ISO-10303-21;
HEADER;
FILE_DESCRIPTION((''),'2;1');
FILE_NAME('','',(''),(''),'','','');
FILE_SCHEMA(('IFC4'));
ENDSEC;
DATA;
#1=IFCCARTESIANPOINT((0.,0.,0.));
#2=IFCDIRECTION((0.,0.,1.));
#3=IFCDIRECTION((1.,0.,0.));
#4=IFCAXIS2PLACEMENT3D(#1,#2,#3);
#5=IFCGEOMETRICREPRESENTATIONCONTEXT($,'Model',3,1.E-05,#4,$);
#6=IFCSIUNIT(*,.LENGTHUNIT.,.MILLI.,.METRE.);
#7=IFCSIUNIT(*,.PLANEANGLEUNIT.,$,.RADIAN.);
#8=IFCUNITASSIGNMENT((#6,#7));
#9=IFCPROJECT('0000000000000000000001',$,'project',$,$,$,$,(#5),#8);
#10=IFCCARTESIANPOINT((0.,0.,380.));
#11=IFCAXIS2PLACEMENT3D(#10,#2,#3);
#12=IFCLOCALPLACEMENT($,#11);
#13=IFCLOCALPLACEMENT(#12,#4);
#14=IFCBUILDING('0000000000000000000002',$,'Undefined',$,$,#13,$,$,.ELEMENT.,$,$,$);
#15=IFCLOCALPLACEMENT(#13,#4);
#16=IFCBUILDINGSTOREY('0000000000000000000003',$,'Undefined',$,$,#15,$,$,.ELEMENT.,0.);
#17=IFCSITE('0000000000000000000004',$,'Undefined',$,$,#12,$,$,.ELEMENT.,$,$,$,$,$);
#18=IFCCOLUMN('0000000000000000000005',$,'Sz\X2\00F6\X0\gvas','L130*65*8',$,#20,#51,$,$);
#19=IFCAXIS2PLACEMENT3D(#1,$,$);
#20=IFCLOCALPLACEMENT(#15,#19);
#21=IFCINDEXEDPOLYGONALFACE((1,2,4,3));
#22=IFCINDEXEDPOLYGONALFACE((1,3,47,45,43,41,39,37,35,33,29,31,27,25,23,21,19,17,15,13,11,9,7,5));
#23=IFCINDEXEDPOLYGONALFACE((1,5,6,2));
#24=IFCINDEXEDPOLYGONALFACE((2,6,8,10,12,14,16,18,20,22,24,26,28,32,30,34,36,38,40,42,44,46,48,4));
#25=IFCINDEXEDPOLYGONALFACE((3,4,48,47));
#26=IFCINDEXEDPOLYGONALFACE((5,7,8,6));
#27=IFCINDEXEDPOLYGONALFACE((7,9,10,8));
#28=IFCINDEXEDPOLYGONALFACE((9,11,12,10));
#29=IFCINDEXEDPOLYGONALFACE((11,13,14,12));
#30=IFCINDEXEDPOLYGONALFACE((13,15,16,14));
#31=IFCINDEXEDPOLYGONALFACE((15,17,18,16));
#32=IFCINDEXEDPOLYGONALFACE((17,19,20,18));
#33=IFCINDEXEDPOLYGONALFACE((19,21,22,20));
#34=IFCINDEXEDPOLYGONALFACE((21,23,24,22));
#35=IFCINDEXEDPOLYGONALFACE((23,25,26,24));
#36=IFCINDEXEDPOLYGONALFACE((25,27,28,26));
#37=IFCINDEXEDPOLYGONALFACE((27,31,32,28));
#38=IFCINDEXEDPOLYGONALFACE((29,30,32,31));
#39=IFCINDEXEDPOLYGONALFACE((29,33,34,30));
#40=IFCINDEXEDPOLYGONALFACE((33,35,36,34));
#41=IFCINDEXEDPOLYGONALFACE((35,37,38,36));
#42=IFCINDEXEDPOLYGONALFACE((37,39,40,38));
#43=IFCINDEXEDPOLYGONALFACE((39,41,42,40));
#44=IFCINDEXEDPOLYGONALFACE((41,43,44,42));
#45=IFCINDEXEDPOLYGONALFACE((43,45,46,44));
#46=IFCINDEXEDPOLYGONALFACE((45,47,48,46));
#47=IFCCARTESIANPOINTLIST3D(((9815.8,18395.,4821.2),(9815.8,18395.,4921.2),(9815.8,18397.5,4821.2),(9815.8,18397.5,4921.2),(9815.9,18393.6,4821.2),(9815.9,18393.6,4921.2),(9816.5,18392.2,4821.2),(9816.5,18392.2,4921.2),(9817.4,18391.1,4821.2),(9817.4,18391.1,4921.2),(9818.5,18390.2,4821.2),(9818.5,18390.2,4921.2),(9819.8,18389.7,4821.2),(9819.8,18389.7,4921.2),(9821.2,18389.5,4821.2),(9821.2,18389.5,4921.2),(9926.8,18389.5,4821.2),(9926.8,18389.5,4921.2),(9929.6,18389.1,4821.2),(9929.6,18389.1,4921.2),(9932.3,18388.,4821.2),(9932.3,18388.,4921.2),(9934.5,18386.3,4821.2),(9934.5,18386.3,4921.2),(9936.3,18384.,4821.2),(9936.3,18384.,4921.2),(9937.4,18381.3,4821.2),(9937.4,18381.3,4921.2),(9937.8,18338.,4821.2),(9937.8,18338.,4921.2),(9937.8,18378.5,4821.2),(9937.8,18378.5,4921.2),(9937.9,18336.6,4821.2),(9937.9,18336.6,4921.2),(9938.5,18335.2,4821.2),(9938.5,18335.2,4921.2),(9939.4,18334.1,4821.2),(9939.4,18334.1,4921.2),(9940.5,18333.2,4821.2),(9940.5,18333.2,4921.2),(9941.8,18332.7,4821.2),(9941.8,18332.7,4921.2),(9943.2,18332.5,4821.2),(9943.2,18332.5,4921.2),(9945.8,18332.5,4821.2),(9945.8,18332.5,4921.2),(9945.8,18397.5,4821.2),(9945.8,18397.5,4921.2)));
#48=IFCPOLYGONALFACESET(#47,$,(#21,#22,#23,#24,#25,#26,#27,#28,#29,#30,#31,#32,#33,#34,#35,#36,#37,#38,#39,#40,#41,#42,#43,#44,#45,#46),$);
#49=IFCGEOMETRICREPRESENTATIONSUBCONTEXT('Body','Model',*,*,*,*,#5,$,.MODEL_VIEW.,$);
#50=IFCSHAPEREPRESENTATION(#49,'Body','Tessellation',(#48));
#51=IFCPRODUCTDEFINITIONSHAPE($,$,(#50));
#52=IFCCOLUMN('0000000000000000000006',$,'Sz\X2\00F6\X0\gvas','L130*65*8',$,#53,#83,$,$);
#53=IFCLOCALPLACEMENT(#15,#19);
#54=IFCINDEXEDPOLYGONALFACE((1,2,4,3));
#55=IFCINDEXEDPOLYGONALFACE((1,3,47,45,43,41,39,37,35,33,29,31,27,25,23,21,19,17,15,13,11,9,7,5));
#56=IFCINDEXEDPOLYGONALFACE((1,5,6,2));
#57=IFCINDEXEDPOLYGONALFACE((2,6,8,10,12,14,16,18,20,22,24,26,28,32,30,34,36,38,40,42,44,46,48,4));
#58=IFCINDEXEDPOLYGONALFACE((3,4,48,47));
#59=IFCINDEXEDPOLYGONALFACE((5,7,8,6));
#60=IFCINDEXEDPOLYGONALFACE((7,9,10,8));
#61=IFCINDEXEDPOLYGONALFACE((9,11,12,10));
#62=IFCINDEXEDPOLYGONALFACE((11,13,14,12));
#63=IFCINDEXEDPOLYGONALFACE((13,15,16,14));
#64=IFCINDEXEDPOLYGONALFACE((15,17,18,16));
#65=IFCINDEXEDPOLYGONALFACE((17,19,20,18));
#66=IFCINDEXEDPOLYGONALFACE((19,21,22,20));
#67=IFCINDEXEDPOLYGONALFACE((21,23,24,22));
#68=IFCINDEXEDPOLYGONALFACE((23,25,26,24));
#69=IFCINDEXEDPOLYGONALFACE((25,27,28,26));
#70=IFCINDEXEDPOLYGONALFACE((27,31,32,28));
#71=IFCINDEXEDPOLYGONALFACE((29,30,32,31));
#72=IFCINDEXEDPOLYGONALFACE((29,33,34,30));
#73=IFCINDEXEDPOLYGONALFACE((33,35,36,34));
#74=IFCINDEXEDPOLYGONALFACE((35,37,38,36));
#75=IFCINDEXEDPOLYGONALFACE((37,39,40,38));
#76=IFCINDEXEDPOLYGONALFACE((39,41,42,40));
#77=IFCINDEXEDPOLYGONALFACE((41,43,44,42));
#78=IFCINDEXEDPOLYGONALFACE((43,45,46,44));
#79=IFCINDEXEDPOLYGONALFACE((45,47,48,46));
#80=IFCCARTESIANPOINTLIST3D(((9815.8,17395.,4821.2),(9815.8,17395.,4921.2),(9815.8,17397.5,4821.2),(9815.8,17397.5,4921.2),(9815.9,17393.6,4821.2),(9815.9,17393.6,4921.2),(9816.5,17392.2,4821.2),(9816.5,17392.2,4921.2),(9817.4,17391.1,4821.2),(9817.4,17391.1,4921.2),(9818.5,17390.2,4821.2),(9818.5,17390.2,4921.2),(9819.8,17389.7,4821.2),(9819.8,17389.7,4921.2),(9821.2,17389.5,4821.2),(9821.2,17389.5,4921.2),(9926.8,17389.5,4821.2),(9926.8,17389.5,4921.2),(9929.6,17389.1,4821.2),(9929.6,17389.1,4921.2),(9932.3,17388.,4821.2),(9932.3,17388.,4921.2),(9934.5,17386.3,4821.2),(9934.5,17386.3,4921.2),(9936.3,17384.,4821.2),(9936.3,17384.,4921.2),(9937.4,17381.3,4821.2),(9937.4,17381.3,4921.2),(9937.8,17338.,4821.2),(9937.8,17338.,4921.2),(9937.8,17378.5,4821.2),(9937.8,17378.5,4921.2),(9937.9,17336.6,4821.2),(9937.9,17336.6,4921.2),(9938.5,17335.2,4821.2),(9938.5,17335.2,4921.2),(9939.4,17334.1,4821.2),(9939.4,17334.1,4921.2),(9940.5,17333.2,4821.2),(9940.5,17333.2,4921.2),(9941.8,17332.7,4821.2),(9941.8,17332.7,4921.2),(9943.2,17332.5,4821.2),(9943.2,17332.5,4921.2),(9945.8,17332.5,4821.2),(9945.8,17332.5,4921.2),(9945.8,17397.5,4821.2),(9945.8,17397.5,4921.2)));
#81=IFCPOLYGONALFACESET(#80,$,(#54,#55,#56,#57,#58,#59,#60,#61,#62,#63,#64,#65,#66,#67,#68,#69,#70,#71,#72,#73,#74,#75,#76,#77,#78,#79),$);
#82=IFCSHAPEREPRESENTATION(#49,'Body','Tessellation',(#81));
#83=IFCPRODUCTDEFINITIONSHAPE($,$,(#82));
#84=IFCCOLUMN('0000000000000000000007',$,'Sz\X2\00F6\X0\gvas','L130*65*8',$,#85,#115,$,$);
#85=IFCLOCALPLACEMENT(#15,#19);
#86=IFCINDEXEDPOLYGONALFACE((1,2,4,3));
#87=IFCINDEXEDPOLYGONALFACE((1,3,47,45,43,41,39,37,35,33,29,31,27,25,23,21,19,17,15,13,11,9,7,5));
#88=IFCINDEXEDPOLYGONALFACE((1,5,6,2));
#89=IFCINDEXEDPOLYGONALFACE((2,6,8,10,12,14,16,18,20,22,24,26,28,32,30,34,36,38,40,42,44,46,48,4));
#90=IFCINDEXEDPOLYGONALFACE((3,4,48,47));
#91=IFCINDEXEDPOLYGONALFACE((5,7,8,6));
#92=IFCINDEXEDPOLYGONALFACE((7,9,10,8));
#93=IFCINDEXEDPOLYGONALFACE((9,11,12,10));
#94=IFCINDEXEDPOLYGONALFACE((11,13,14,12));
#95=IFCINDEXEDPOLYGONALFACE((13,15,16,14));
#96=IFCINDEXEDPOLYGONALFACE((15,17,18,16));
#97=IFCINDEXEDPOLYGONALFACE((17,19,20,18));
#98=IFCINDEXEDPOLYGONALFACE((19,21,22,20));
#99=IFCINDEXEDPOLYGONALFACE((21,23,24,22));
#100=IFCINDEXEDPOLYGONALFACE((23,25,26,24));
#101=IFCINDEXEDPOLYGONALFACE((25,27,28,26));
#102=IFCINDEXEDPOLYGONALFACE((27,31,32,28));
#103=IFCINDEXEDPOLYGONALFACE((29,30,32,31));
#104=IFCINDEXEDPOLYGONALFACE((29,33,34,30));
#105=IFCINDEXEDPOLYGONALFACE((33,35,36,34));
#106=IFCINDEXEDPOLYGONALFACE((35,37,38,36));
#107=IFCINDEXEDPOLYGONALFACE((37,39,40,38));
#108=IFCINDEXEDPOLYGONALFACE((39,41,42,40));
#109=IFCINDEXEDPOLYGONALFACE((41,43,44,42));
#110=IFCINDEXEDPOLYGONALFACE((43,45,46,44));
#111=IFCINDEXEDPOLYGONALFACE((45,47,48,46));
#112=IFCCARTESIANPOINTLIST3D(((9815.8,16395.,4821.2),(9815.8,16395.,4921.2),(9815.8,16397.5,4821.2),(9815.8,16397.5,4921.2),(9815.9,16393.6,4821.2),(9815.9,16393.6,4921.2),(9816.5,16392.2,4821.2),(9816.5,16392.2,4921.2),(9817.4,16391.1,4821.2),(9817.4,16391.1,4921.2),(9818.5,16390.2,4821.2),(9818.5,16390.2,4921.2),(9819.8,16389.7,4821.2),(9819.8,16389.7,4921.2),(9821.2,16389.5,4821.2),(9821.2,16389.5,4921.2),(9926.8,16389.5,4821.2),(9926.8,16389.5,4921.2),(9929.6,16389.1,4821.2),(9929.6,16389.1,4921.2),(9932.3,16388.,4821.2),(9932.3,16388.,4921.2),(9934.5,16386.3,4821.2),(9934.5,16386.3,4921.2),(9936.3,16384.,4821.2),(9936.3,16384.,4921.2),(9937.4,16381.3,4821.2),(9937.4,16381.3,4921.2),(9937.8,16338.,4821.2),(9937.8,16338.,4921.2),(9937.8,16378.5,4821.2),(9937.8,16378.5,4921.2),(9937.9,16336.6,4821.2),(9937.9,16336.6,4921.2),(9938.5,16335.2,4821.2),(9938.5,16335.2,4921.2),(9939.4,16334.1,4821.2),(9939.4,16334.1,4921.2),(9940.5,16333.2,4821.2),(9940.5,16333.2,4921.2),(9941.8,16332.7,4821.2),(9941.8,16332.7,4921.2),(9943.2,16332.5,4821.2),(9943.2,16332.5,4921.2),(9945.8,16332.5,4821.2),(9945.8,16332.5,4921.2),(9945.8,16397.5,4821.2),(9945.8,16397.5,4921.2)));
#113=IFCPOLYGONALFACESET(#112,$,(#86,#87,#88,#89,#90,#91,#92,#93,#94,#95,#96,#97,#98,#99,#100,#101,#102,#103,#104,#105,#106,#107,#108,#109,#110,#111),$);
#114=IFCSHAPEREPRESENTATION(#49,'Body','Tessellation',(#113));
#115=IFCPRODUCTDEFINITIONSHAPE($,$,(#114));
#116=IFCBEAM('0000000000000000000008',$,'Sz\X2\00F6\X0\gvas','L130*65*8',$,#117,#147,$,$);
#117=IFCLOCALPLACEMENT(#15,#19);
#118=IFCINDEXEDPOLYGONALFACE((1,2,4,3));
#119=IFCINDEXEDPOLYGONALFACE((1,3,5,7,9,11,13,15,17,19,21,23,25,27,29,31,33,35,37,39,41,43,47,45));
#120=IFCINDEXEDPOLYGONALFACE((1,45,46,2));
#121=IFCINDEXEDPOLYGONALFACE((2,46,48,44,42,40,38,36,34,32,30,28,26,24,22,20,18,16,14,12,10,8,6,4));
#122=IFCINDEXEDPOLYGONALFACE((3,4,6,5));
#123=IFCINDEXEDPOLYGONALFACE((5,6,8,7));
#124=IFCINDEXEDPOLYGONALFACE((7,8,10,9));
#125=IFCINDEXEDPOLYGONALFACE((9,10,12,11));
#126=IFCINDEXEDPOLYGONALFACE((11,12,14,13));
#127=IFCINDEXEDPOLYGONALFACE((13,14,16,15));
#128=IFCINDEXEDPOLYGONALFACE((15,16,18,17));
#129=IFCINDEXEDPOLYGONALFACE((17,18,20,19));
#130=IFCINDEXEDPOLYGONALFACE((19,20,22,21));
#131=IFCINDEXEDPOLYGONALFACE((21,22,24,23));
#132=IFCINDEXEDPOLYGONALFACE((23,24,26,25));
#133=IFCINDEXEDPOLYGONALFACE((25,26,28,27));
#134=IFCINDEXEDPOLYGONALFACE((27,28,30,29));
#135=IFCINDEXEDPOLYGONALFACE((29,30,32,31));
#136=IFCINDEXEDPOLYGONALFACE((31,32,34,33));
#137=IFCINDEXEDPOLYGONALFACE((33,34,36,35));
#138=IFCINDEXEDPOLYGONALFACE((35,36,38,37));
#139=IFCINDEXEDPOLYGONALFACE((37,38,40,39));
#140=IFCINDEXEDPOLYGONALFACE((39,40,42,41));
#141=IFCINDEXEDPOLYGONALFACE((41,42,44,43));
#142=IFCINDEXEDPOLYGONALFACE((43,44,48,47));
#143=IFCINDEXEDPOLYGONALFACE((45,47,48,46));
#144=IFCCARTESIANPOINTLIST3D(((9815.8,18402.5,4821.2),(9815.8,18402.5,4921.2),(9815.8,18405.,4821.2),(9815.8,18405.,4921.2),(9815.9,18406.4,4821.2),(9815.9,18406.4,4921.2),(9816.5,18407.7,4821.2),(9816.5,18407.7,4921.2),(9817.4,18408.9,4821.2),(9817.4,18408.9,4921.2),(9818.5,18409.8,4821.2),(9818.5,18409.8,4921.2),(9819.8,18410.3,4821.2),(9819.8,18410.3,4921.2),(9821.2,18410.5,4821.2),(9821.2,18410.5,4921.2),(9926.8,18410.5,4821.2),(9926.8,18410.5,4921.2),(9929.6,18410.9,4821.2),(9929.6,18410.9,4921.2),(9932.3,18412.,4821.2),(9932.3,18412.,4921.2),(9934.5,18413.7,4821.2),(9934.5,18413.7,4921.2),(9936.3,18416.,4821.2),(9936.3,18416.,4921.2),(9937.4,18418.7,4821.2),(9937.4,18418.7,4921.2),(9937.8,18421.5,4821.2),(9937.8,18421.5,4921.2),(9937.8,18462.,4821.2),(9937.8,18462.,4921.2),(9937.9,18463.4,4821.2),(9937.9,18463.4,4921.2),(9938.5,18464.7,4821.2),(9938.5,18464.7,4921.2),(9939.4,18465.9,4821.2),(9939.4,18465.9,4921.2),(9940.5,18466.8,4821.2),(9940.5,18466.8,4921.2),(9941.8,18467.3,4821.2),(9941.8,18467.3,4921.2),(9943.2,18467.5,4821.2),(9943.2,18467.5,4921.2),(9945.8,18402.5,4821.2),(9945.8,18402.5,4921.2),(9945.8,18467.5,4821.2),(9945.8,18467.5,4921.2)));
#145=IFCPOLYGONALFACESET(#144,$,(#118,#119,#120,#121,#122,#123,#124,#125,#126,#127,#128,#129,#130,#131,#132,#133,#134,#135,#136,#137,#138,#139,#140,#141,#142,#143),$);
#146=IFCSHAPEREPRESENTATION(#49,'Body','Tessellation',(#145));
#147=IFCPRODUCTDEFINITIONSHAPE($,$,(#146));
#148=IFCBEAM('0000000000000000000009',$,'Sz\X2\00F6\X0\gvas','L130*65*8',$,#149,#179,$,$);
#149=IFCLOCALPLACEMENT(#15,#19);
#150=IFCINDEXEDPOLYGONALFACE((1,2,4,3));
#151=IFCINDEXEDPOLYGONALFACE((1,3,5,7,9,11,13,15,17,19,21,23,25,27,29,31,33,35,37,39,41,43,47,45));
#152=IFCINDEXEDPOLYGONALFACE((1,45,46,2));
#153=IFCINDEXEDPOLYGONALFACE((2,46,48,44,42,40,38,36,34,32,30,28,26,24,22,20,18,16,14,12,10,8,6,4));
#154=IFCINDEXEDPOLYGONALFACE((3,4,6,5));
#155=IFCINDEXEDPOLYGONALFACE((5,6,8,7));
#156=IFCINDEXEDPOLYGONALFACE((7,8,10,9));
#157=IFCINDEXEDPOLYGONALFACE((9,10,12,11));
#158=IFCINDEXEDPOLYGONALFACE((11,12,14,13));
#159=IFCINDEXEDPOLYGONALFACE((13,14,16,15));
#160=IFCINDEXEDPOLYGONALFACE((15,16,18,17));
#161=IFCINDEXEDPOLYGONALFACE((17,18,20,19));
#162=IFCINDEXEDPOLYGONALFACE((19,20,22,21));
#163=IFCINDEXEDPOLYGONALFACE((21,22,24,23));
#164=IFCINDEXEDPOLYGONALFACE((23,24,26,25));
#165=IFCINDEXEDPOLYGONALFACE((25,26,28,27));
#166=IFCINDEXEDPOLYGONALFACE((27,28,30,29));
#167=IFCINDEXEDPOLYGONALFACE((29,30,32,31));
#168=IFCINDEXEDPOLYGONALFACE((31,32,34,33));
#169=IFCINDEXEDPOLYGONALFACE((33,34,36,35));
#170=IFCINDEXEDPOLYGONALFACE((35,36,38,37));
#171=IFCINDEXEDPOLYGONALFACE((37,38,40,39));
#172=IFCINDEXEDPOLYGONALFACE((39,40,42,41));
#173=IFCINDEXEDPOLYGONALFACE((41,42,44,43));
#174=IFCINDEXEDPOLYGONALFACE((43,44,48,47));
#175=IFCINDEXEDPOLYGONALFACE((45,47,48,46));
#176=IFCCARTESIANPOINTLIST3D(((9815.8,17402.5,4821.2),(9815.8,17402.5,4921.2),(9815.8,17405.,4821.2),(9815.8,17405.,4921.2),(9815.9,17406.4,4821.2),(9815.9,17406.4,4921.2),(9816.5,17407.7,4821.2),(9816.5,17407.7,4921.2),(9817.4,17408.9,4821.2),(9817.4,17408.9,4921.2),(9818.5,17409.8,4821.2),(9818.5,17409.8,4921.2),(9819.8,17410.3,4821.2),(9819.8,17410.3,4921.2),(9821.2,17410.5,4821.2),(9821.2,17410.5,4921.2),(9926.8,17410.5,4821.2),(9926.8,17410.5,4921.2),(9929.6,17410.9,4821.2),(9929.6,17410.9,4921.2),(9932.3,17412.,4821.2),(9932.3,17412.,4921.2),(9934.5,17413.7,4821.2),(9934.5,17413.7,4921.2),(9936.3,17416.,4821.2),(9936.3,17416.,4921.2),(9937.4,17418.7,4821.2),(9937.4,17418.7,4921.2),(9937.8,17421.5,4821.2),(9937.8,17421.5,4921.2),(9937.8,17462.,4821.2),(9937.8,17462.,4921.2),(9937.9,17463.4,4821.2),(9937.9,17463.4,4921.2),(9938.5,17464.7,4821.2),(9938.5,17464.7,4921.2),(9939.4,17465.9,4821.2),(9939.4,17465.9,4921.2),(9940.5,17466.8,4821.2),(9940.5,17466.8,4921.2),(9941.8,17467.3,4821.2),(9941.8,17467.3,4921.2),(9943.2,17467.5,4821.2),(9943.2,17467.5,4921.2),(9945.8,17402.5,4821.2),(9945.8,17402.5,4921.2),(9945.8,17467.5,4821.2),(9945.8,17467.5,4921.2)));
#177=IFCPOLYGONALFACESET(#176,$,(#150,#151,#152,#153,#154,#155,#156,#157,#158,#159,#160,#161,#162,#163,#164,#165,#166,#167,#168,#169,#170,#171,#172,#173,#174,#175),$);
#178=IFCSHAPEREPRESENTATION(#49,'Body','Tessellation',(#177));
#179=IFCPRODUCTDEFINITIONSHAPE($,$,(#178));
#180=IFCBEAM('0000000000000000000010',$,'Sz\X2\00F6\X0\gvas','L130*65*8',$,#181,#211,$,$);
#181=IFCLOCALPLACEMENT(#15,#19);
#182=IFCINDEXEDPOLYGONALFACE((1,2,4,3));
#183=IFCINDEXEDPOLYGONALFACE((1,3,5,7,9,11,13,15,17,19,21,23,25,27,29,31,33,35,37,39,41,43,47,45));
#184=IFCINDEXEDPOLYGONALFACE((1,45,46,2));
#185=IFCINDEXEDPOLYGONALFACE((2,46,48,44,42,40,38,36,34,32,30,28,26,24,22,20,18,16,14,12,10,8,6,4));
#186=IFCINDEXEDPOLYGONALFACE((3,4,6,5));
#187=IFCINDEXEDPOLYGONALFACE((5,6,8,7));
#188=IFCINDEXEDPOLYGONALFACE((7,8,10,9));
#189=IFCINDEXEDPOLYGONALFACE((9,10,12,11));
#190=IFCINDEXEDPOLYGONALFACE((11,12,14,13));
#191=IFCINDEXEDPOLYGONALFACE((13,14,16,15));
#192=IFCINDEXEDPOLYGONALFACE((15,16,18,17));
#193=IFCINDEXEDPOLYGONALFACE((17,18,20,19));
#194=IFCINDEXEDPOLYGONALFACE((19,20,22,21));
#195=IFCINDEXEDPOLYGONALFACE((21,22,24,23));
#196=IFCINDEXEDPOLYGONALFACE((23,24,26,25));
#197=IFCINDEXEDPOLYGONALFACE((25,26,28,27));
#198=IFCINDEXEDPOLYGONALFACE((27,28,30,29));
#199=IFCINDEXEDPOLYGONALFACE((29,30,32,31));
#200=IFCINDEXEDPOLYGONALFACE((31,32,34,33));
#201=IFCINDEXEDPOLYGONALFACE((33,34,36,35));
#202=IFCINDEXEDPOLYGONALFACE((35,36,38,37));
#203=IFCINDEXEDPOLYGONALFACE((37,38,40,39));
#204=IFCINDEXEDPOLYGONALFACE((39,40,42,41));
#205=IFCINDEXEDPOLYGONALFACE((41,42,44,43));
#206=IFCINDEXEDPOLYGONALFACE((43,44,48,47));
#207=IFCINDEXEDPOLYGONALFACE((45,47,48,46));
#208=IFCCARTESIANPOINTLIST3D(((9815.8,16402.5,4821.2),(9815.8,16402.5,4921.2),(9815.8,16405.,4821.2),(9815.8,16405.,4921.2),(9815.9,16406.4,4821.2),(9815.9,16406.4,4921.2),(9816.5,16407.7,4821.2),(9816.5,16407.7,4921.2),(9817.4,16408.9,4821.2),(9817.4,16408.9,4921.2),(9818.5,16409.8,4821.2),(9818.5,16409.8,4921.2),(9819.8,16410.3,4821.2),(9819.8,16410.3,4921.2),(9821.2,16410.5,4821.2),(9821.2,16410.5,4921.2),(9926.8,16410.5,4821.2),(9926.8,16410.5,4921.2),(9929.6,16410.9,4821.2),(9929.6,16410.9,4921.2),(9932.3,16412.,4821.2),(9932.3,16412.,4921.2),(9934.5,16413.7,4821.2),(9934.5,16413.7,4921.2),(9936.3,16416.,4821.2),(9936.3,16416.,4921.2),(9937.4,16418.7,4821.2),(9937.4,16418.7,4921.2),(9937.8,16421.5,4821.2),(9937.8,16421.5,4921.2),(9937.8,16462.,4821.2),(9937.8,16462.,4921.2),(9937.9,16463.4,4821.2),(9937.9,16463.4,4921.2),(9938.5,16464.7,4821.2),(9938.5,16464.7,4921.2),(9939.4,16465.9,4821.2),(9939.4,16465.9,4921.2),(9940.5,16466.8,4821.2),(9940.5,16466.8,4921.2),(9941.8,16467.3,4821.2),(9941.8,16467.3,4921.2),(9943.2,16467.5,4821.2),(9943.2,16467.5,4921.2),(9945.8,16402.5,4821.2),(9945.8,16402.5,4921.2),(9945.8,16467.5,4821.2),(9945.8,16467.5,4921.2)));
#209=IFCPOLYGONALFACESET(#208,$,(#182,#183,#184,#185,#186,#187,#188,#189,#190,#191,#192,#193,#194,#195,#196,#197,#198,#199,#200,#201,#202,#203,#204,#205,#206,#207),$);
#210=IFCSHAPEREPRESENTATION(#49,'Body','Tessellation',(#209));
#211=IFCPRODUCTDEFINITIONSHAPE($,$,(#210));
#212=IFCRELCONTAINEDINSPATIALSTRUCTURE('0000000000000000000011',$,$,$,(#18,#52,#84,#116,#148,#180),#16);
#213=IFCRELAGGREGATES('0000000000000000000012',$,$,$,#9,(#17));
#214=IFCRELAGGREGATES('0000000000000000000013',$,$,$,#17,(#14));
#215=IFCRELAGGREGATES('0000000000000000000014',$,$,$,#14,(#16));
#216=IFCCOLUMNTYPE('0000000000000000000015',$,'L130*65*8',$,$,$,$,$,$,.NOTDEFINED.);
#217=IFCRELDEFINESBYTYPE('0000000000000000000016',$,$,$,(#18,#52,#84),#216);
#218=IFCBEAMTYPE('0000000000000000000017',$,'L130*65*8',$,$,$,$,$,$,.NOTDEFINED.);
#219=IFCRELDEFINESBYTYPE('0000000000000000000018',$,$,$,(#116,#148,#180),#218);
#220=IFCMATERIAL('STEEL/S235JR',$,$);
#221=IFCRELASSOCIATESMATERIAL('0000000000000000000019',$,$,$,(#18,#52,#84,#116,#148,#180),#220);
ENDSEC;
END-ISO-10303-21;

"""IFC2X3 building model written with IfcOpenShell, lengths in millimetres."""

from ifc_helpers import new_model, si_unit, frame, origin_with_axes, origin_2d_with_axis, place, context, subcontext, project, spatial, l_section, extrude, material, type_object, element, save


model = new_model("IFC2X3")

# Units and contexts
model_context = context("Model", 3, precision=1e-05, world=origin_with_axes())
body_context = subcontext(model_context, "Body", "Model", "MODEL_VIEW")
ifc_project = project(units=[si_unit("LENGTHUNIT", "METRE", prefix="MILLI"), si_unit("PLANEANGLEUNIT", "RADIAN")], contexts=[model_context])

# Site, building, storey
site_placement = place(None, frame((0.0, 0.0, 380.0), z_axis=(0.0, 0.0, 1.0), x_axis=(1.0, 0.0, 0.0)))
site = spatial("IfcSite", under=ifc_project, at=site_placement, Name="Undefined", CompositionType="ELEMENT")
building_placement = place(site_placement, origin_with_axes())
building = spatial("IfcBuilding", under=site, at=building_placement, Name="Undefined", CompositionType="ELEMENT")
storey_placement = place(building_placement, origin_with_axes())
storey = spatial("IfcBuildingStorey", under=building, at=storey_placement, Name="Undefined", CompositionType="ELEMENT", Elevation=0.0)

# Columns
ifc_material_1 = material(Name="STEEL/S235JR")
column_type = type_object("IfcColumnType", Name="L130*65*8", PredefinedType="NOTDEFINED")
for number, where, z_axis, x_axis, name in (
    (1, (9880.8, 18365.0, 4821.2), (0.0, 0.0, 1.0), (-1.0, 0.0, 0.0), "Szögvas"),
    (2, (9880.8, 17365.0, 4821.2), (0.0, 0.0, 1.0), (-1.0, 0.0, 0.0), "Szögvas"),
    (3, (9880.8, 16365.0, 4821.2), (0.0, 0.0, 1.0), (-1.0, 0.0, 0.0), "Szögvas"),
):
    element("IfcColumn", number, at=place(storey_placement, frame(where, z_axis=z_axis, x_axis=x_axis)), inside=storey, type_object=column_type, material=ifc_material_1, Name=name, Description="L130*65*8", context=body_context, shape_type="SweptSolid", body=[
        extrude(l_section(Depth=130.0, Width=65.0, Thickness=8.0, FilletRadius=11.0, EdgeRadius=5.5, at=origin_2d_with_axis()), frame((0.0, 0.0, 100.0), z_axis=(0.0, 0.0, -1.0), x_axis=(0.0, 1.0, 0.0)), (0.0, 0.0, 1.0), 100.0),
    ])

# Beams
beam_type_1 = type_object("IfcBeamType", Name="L130*65*8", PredefinedType="NOTDEFINED")
for number, where, z_axis, x_axis, name in (
    (4, (9880.8, 18435.0, 4921.2), (-1.0, 0.0, 0.0), (0.0, 0.0, -1.0), "Szögvas"),
    (5, (9880.8, 17435.0, 4921.2), (-1.0, 0.0, 0.0), (0.0, 0.0, -1.0), "Szögvas"),
    (6, (9880.8, 16435.0, 4921.2), (-1.0, 0.0, 0.0), (0.0, 0.0, -1.0), "Szögvas"),
):
    element("IfcBeam", number, at=place(storey_placement, frame(where, z_axis=z_axis, x_axis=x_axis)), inside=storey, type_object=beam_type_1, material=ifc_material_1, Name=name, Description="L130*65*8", context=body_context, shape_type="SweptSolid", body=[
        extrude(l_section(Depth=130.0, Width=65.0, Thickness=8.0, FilletRadius=11.0, EdgeRadius=5.5, at=origin_2d_with_axis()), frame((100.0, 0.0, 0.0), z_axis=(-1.0, 0.0, 0.0), x_axis=(0.0, -1.0, 0.0)), (0.0, 0.0, 1.0), 100.0),
    ])

save(model, "model.ifc")
